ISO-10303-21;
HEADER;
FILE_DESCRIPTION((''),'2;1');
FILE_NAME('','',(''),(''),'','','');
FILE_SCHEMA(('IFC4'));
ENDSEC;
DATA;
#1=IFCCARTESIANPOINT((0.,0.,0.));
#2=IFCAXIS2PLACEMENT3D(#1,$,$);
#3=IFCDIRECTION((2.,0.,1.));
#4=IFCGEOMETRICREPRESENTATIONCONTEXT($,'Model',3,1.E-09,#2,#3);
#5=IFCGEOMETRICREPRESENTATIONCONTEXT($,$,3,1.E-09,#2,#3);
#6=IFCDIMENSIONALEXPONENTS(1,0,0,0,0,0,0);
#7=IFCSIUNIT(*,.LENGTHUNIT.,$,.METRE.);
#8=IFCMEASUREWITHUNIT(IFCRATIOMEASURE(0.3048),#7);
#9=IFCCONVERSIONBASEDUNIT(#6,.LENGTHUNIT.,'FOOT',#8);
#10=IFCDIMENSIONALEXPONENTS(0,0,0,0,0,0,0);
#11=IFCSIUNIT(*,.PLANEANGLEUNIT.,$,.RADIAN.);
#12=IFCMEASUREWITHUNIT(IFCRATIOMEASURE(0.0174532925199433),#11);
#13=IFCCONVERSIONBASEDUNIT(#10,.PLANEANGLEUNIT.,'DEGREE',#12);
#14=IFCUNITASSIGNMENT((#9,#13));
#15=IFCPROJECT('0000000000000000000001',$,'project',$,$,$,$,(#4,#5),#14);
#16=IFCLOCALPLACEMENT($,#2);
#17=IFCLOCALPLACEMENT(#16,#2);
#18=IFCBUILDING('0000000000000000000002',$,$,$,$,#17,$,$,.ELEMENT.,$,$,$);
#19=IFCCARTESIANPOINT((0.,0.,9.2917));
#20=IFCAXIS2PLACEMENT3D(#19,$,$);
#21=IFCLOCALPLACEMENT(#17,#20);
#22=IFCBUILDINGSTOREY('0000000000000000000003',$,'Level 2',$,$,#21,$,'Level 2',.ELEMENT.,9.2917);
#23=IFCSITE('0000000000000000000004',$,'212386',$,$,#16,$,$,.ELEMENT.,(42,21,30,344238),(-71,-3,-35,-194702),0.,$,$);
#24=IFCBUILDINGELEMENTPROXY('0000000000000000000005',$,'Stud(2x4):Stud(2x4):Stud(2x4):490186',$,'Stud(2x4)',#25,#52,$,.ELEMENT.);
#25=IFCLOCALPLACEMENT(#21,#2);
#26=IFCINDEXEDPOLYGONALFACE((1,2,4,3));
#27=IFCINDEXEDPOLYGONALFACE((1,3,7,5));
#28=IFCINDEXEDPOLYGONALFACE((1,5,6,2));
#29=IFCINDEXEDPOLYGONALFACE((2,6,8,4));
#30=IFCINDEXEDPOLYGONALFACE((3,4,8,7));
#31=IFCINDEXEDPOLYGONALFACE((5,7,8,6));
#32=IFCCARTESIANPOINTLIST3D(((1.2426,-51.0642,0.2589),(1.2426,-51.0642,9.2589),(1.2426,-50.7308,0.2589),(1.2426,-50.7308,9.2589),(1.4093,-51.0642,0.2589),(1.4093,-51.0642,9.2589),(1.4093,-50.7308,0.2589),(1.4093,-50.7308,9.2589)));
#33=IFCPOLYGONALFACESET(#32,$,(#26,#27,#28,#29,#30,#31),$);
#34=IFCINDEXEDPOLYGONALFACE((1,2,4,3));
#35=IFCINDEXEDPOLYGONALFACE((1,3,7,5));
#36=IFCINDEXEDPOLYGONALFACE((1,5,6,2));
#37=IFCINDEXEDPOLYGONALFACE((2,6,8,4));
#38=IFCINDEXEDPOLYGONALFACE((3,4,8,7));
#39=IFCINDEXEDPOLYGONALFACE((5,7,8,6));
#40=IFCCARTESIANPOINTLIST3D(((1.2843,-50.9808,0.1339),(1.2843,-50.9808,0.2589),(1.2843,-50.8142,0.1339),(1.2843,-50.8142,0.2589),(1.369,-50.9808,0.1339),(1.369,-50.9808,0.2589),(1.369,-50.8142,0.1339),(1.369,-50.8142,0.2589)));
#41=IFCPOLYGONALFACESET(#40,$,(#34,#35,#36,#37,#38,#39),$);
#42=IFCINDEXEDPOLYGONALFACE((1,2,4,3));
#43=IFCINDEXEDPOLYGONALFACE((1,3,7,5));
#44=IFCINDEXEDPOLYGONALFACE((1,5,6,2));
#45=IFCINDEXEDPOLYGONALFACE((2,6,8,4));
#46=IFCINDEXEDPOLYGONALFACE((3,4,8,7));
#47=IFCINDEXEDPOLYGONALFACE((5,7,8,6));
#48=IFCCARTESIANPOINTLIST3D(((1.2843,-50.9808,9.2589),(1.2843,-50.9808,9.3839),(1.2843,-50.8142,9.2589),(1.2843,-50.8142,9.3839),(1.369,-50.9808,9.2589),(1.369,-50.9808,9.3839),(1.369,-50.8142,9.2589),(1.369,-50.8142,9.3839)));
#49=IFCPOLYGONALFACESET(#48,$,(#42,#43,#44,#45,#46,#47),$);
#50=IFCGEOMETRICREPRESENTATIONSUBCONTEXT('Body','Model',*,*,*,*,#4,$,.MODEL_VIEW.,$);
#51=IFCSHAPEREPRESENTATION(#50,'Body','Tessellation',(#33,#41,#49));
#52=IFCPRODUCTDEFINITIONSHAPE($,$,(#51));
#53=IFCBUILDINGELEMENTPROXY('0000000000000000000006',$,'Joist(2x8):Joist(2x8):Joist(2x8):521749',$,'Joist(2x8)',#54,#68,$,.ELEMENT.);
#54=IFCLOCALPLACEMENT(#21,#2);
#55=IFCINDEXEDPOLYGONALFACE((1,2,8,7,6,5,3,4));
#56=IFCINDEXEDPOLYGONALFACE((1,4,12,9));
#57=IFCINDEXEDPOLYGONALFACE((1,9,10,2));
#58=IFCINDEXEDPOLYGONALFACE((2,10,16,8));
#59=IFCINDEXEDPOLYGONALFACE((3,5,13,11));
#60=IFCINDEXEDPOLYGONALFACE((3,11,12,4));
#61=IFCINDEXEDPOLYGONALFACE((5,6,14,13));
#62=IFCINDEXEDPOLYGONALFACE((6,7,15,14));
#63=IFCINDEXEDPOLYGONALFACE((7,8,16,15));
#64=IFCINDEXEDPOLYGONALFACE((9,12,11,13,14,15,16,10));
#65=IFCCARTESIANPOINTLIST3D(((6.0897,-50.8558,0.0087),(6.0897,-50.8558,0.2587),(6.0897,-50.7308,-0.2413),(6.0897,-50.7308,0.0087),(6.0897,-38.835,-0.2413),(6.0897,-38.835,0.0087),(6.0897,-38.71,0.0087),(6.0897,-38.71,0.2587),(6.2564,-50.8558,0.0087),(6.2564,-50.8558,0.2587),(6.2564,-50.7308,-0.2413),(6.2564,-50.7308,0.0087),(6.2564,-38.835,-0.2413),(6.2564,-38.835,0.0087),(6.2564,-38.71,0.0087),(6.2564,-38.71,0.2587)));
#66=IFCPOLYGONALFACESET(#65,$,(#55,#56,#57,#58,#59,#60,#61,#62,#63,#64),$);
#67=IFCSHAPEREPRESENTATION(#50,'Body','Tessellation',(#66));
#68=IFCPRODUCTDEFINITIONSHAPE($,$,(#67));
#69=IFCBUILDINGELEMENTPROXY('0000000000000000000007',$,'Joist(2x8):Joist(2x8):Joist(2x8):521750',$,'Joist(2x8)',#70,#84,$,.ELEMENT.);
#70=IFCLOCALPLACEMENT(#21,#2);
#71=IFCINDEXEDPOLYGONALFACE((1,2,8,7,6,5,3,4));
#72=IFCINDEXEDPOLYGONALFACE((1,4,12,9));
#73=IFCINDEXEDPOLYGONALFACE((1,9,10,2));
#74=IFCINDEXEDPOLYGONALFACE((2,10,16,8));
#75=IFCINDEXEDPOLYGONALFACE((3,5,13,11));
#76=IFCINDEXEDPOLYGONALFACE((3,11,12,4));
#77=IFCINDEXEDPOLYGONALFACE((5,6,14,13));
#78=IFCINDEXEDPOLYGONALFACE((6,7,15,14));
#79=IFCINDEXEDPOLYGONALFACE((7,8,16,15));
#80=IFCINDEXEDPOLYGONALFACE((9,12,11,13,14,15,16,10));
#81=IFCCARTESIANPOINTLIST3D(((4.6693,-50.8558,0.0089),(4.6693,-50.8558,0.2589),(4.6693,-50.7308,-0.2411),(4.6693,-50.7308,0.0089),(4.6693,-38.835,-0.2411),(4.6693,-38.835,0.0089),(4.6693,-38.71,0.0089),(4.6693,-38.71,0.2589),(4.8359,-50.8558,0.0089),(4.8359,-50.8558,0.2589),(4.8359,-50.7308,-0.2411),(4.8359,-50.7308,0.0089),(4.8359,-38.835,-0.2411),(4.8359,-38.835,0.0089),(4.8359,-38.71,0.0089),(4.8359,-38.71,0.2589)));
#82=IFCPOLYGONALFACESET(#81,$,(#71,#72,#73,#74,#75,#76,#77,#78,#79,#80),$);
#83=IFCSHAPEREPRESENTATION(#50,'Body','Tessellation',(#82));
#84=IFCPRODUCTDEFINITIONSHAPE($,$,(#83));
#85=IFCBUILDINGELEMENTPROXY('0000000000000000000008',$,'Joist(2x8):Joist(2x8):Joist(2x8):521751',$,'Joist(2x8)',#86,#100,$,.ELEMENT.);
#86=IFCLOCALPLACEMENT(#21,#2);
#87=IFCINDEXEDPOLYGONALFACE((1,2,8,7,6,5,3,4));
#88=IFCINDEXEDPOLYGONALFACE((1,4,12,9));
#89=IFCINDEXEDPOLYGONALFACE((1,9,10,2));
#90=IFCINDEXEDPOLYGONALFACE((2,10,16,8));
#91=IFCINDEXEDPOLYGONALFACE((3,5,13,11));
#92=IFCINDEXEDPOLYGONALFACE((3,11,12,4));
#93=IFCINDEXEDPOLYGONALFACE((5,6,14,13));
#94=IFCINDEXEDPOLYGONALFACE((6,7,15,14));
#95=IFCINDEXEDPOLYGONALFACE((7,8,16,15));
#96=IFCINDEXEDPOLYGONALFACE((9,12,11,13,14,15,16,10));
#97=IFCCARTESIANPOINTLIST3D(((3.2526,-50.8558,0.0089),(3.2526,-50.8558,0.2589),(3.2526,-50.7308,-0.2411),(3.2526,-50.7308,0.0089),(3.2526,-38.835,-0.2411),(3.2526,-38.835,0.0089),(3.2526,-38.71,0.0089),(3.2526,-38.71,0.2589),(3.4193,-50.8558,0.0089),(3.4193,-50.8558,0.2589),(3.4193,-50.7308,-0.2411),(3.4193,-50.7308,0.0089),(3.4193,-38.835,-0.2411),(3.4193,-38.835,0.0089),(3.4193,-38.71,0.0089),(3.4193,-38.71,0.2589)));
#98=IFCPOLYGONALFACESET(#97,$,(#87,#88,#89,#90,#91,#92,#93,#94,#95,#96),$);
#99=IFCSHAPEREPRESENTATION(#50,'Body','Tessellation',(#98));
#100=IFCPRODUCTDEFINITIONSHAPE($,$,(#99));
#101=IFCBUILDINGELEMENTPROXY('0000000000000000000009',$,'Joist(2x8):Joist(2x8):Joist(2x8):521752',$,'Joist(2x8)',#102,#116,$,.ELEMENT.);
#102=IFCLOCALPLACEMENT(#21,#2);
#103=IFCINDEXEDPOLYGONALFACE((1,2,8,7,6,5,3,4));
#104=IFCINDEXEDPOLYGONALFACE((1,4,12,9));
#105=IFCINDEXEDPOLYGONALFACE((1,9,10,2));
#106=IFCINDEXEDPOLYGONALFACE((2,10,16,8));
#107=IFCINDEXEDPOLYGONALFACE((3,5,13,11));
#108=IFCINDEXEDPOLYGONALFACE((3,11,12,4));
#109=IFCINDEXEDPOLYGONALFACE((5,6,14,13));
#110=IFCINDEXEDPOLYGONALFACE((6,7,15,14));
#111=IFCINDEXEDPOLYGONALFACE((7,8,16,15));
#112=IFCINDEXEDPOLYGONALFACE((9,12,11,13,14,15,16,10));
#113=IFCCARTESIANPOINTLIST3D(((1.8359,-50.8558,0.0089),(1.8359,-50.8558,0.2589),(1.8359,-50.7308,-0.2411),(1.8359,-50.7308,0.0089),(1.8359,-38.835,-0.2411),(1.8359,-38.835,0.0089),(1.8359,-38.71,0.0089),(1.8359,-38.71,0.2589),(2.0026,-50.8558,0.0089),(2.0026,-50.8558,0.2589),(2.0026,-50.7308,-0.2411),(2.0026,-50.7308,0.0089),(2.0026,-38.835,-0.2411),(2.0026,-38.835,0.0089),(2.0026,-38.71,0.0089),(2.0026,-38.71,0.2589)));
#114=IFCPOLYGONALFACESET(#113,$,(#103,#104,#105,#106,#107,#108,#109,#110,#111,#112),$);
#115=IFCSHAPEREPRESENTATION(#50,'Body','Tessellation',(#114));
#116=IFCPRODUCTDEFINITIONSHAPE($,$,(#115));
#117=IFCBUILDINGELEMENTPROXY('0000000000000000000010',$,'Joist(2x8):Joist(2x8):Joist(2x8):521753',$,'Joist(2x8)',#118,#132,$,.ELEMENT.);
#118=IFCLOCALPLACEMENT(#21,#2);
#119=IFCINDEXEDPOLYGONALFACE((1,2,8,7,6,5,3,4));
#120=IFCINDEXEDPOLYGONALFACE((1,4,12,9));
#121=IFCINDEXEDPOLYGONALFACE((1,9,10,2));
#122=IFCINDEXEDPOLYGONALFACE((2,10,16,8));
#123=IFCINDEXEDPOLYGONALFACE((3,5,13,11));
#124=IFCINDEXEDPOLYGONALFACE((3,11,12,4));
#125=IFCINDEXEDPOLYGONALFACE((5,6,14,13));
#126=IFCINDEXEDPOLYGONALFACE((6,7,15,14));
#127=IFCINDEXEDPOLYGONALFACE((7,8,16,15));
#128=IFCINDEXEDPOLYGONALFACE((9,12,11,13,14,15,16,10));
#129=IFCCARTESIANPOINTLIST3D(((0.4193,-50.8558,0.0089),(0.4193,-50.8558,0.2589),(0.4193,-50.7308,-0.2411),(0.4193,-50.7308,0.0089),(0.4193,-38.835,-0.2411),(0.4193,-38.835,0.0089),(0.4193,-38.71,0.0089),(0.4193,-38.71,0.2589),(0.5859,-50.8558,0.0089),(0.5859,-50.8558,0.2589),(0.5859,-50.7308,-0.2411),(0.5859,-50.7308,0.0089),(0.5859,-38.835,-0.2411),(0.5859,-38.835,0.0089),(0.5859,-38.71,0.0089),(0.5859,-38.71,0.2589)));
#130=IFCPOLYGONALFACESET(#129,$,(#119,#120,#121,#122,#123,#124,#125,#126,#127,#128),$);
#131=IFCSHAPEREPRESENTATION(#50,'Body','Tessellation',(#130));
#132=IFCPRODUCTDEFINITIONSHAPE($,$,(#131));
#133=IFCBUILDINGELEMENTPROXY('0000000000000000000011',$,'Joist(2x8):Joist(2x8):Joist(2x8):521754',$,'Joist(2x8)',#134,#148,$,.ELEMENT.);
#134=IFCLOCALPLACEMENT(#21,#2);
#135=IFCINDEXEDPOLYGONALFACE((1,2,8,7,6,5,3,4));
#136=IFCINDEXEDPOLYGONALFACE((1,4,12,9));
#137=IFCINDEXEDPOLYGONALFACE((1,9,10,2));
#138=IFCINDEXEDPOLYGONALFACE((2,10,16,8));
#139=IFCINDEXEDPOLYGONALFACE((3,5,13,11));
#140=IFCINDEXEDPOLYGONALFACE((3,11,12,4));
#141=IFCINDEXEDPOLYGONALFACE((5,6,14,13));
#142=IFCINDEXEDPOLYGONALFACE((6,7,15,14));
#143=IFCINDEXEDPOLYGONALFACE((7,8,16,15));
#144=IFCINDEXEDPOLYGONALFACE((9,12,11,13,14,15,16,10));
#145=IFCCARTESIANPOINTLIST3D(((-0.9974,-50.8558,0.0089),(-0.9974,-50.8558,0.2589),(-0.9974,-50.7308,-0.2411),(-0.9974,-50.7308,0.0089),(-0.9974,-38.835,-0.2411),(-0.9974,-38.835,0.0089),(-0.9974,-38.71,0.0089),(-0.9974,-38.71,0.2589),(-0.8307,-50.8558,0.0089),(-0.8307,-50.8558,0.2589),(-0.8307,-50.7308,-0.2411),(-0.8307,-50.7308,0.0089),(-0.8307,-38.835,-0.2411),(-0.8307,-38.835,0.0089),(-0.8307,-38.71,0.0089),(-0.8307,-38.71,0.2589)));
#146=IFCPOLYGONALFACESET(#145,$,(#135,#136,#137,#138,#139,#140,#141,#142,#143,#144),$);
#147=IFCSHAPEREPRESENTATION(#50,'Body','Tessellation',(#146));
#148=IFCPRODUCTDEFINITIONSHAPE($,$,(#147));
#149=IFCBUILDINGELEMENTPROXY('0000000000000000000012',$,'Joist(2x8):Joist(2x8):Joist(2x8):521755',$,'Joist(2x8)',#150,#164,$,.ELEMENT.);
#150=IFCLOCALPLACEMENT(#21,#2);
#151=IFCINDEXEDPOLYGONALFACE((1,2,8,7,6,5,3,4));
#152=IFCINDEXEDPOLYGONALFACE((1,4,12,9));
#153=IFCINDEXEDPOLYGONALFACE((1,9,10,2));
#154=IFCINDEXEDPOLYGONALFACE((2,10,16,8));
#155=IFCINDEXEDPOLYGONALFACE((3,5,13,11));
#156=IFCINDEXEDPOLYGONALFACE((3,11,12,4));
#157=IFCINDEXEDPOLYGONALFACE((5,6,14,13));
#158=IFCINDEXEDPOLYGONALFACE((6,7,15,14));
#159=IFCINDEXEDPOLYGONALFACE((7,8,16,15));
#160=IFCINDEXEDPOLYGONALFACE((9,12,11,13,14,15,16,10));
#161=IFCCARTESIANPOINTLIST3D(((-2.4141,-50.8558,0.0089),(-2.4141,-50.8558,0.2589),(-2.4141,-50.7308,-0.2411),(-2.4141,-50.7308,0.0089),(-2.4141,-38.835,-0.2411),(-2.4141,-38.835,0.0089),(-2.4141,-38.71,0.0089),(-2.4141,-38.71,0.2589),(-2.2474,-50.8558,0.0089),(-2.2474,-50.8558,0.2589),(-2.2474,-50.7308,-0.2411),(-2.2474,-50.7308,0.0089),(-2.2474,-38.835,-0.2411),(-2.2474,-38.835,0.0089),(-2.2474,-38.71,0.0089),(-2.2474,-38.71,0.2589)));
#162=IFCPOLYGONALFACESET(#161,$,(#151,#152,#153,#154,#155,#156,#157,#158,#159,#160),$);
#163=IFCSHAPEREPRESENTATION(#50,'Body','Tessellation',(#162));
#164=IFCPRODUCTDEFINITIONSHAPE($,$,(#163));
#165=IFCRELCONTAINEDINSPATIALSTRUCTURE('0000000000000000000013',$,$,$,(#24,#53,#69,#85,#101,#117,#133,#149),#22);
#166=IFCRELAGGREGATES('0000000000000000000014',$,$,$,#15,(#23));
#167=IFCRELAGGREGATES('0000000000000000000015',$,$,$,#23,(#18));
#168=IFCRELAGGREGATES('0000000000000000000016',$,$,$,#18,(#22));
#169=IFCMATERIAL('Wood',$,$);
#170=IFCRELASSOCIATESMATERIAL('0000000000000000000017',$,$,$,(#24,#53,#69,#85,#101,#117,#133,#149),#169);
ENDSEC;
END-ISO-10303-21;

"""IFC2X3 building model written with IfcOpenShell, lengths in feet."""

from ifc_helpers import new_model, entity, si_unit, converted_unit, direction, frame, frame_2d, origin, place, context, subcontext, project, spatial, polyline, rectangle, outline, extrude, source, transform, mapped, material, element, save


model = new_model("IFC2X3")

# Units and contexts
model_context = context("Model", 3, precision=1e-09, world=origin(), true_north=direction((2.0, 0.0, 1.0)))
context_of_model = context(None, 3, precision=1e-09, world=origin(), true_north=direction((2.0, 0.0, 1.0)))
body_context = subcontext(model_context, "Body", "Model", "MODEL_VIEW")
ifc_project = project(units=[converted_unit("LENGTHUNIT", "FOOT", entity("IfcRatioMeasure", 0.3048), si_unit("LENGTHUNIT", "METRE"), dimensions=[1, 0, 0, 0, 0, 0, 0]), converted_unit("PLANEANGLEUNIT", "DEGREE", entity("IfcRatioMeasure", 0.0174532925199433), si_unit("PLANEANGLEUNIT", "RADIAN"), dimensions=[0, 0, 0, 0, 0, 0, 0])], contexts=[model_context, context_of_model])

# Site, building, storey
site_placement = place(None, origin())
site = spatial("IfcSite", under=ifc_project, at=site_placement, Name="212386", CompositionType="ELEMENT", RefLatitude=(42, 21, 30, 344238), RefLongitude=(-71, -3, -35, -194702), RefElevation=0.0)
building_placement = place(site_placement, origin())
building = spatial("IfcBuilding", under=site, at=building_placement, CompositionType="ELEMENT")
storey_placement = place(building_placement, frame((0.0, 0.0, 9.2917)))
storey = spatial("IfcBuildingStorey", under=building, at=storey_placement, Name="Level 2", LongName="Level 2", CompositionType="ELEMENT", Elevation=9.2917)

# Building element proxies
ifc_material = material(Name="Wood")
shared_shape_1 = source(origin(), body_context, "Body", "SweptSolid", [
    extrude(rectangle(XDim=0.3333, YDim=0.1667, at=frame_2d((0.0, 0.0), x_axis=(1.0, 0.0))), frame((1.326, -50.8975, 9.5506), z_axis=(0.0, 0.0, 1.0), x_axis=(0.0, -1.0, 0.0)), (0.0, 0.0, 1.0), 9.0),
    extrude(rectangle(XDim=0.1667, YDim=0.0847, at=frame_2d((0.0, 0.0), x_axis=(1.0, 0.0))), frame((1.3266, -50.8975, 9.4256), z_axis=(0.0, 0.0, 1.0), x_axis=(0.0, -1.0, 0.0)), (0.0, 0.0, 1.0), 0.125),
    extrude(rectangle(XDim=0.0847, YDim=0.1667, at=frame_2d((0.0, 0.0), x_axis=(1.0, 0.0))), frame((1.3266, -50.8975, 18.5506)), (0.0, 0.0, 1.0), 0.125),
])
proxy_1_placement = place(storey_placement, frame((0.0, 0.0, -9.2917)))
element("IfcBuildingElementProxy", 1, at=proxy_1_placement, inside=storey, material=ifc_material, Name="Stud(2x4):Stud(2x4):Stud(2x4):490186", ObjectType="Stud(2x4)", CompositionType="ELEMENT", context=body_context, shape_type="MappedRepresentation", body=[
    mapped(shared_shape_1, transform((0.0, 0.0, 0.0), scale=1.0)),
])
shared_shape_2 = source(origin(), body_context, "Body", "SweptSolid", [
    extrude(outline(polyline([(-0.25, -6.0729), (0.0, -6.0729), (0.0, -5.9479), (0.25, -5.9479), (0.25, 5.9479), (0.0, 5.9479), (0.0, 6.0729), (-0.25, 6.0729), (-0.25, -6.0729)])), frame((6.0897, -44.7829, 9.3004), z_axis=(1.0, 0.0, 0.0), x_axis=(0.0, 0.0, -1.0)), (0.0, 0.0, 1.0), 0.1667),
])
proxy_2_placement = place(storey_placement, frame((0.0, 0.0, -9.2917)))
element("IfcBuildingElementProxy", 2, at=proxy_2_placement, inside=storey, material=ifc_material, Name="Joist(2x8):Joist(2x8):Joist(2x8):521749", ObjectType="Joist(2x8)", CompositionType="ELEMENT", context=body_context, shape_type="MappedRepresentation", body=[
    mapped(shared_shape_2, transform((0.0, 0.0, 0.0), scale=1.0)),
])
shared_shape_3 = source(origin(), body_context, "Body", "SweptSolid", [
    extrude(outline(polyline([(-0.25, -6.0729), (0.0, -6.0729), (0.0, -5.9479), (0.25, -5.9479), (0.25, 5.9479), (0.0, 5.9479), (0.0, 6.0729), (-0.25, 6.0729), (-0.25, -6.0729)])), frame((4.6693, -44.7829, 9.3006), z_axis=(1.0, 0.0, 0.0), x_axis=(0.0, 0.0, -1.0)), (0.0, 0.0, 1.0), 0.1667),
])
proxy_3_placement = place(storey_placement, frame((0.0, 0.0, -9.2917)))
element("IfcBuildingElementProxy", 3, at=proxy_3_placement, inside=storey, material=ifc_material, Name="Joist(2x8):Joist(2x8):Joist(2x8):521750", ObjectType="Joist(2x8)", CompositionType="ELEMENT", context=body_context, shape_type="MappedRepresentation", body=[
    mapped(shared_shape_3, transform((0.0, 0.0, 0.0), scale=1.0)),
])
shared_shape_4 = source(origin(), body_context, "Body", "SweptSolid", [
    extrude(outline(polyline([(-0.25, -6.0729), (0.0, -6.0729), (0.0, -5.9479), (0.25, -5.9479), (0.25, 5.9479), (0.0, 5.9479), (0.0, 6.0729), (-0.25, 6.0729), (-0.25, -6.0729)])), frame((3.2526, -44.7829, 9.3006), z_axis=(1.0, 0.0, 0.0), x_axis=(0.0, 0.0, -1.0)), (0.0, 0.0, 1.0), 0.1667),
])
proxy_4_placement = place(storey_placement, frame((0.0, 0.0, -9.2917)))
element("IfcBuildingElementProxy", 4, at=proxy_4_placement, inside=storey, material=ifc_material, Name="Joist(2x8):Joist(2x8):Joist(2x8):521751", ObjectType="Joist(2x8)", CompositionType="ELEMENT", context=body_context, shape_type="MappedRepresentation", body=[
    mapped(shared_shape_4, transform((0.0, 0.0, 0.0), scale=1.0)),
])
shared_shape_5 = source(origin(), body_context, "Body", "SweptSolid", [
    extrude(outline(polyline([(-0.25, -6.0729), (0.0, -6.0729), (0.0, -5.9479), (0.25, -5.9479), (0.25, 5.9479), (0.0, 5.9479), (0.0, 6.0729), (-0.25, 6.0729), (-0.25, -6.0729)])), frame((1.8359, -44.7829, 9.3006), z_axis=(1.0, 0.0, 0.0), x_axis=(0.0, 0.0, -1.0)), (0.0, 0.0, 1.0), 0.1667),
])
proxy_5_placement = place(storey_placement, frame((0.0, 0.0, -9.2917)))
element("IfcBuildingElementProxy", 5, at=proxy_5_placement, inside=storey, material=ifc_material, Name="Joist(2x8):Joist(2x8):Joist(2x8):521752", ObjectType="Joist(2x8)", CompositionType="ELEMENT", context=body_context, shape_type="MappedRepresentation", body=[
    mapped(shared_shape_5, transform((0.0, 0.0, 0.0), scale=1.0)),
])
shared_shape_6 = source(origin(), body_context, "Body", "SweptSolid", [
    extrude(outline(polyline([(-0.25, -6.0729), (0.0, -6.0729), (0.0, -5.9479), (0.25, -5.9479), (0.25, 5.9479), (0.0, 5.9479), (0.0, 6.0729), (-0.25, 6.0729), (-0.25, -6.0729)])), frame((0.4193, -44.7829, 9.3006), z_axis=(1.0, 0.0, 0.0), x_axis=(0.0, 0.0, -1.0)), (0.0, 0.0, 1.0), 0.1667),
])
proxy_6_placement = place(storey_placement, frame((0.0, 0.0, -9.2917)))
element("IfcBuildingElementProxy", 6, at=proxy_6_placement, inside=storey, material=ifc_material, Name="Joist(2x8):Joist(2x8):Joist(2x8):521753", ObjectType="Joist(2x8)", CompositionType="ELEMENT", context=body_context, shape_type="MappedRepresentation", body=[
    mapped(shared_shape_6, transform((0.0, 0.0, 0.0), scale=1.0)),
])
shared_shape_7 = source(origin(), body_context, "Body", "SweptSolid", [
    extrude(outline(polyline([(-0.25, -6.0729), (0.0, -6.0729), (0.0, -5.9479), (0.25, -5.9479), (0.25, 5.9479), (0.0, 5.9479), (0.0, 6.0729), (-0.25, 6.0729), (-0.25, -6.0729)])), frame((-0.9974, -44.7829, 9.3006), z_axis=(1.0, 0.0, 0.0), x_axis=(0.0, 0.0, -1.0)), (0.0, 0.0, 1.0), 0.1667),
])
proxy_7_placement = place(storey_placement, frame((0.0, 0.0, -9.2917)))
element("IfcBuildingElementProxy", 7, at=proxy_7_placement, inside=storey, material=ifc_material, Name="Joist(2x8):Joist(2x8):Joist(2x8):521754", ObjectType="Joist(2x8)", CompositionType="ELEMENT", context=body_context, shape_type="MappedRepresentation", body=[
    mapped(shared_shape_7, transform((0.0, 0.0, 0.0), scale=1.0)),
])
shared_shape_8 = source(origin(), body_context, "Body", "SweptSolid", [
    extrude(outline(polyline([(-0.25, -6.0729), (0.0, -6.0729), (0.0, -5.9479), (0.25, -5.9479), (0.25, 5.9479), (0.0, 5.9479), (0.0, 6.0729), (-0.25, 6.0729), (-0.25, -6.0729)])), frame((-2.4141, -44.7829, 9.3006), z_axis=(1.0, 0.0, 0.0), x_axis=(0.0, 0.0, -1.0)), (0.0, 0.0, 1.0), 0.1667),
])
proxy_8_placement = place(storey_placement, frame((0.0, 0.0, -9.2917)))
element("IfcBuildingElementProxy", 8, at=proxy_8_placement, inside=storey, material=ifc_material, Name="Joist(2x8):Joist(2x8):Joist(2x8):521755", ObjectType="Joist(2x8)", CompositionType="ELEMENT", context=body_context, shape_type="MappedRepresentation", body=[
    mapped(shared_shape_8, transform((0.0, 0.0, 0.0), scale=1.0)),
])

save(model, "model.ifc")
